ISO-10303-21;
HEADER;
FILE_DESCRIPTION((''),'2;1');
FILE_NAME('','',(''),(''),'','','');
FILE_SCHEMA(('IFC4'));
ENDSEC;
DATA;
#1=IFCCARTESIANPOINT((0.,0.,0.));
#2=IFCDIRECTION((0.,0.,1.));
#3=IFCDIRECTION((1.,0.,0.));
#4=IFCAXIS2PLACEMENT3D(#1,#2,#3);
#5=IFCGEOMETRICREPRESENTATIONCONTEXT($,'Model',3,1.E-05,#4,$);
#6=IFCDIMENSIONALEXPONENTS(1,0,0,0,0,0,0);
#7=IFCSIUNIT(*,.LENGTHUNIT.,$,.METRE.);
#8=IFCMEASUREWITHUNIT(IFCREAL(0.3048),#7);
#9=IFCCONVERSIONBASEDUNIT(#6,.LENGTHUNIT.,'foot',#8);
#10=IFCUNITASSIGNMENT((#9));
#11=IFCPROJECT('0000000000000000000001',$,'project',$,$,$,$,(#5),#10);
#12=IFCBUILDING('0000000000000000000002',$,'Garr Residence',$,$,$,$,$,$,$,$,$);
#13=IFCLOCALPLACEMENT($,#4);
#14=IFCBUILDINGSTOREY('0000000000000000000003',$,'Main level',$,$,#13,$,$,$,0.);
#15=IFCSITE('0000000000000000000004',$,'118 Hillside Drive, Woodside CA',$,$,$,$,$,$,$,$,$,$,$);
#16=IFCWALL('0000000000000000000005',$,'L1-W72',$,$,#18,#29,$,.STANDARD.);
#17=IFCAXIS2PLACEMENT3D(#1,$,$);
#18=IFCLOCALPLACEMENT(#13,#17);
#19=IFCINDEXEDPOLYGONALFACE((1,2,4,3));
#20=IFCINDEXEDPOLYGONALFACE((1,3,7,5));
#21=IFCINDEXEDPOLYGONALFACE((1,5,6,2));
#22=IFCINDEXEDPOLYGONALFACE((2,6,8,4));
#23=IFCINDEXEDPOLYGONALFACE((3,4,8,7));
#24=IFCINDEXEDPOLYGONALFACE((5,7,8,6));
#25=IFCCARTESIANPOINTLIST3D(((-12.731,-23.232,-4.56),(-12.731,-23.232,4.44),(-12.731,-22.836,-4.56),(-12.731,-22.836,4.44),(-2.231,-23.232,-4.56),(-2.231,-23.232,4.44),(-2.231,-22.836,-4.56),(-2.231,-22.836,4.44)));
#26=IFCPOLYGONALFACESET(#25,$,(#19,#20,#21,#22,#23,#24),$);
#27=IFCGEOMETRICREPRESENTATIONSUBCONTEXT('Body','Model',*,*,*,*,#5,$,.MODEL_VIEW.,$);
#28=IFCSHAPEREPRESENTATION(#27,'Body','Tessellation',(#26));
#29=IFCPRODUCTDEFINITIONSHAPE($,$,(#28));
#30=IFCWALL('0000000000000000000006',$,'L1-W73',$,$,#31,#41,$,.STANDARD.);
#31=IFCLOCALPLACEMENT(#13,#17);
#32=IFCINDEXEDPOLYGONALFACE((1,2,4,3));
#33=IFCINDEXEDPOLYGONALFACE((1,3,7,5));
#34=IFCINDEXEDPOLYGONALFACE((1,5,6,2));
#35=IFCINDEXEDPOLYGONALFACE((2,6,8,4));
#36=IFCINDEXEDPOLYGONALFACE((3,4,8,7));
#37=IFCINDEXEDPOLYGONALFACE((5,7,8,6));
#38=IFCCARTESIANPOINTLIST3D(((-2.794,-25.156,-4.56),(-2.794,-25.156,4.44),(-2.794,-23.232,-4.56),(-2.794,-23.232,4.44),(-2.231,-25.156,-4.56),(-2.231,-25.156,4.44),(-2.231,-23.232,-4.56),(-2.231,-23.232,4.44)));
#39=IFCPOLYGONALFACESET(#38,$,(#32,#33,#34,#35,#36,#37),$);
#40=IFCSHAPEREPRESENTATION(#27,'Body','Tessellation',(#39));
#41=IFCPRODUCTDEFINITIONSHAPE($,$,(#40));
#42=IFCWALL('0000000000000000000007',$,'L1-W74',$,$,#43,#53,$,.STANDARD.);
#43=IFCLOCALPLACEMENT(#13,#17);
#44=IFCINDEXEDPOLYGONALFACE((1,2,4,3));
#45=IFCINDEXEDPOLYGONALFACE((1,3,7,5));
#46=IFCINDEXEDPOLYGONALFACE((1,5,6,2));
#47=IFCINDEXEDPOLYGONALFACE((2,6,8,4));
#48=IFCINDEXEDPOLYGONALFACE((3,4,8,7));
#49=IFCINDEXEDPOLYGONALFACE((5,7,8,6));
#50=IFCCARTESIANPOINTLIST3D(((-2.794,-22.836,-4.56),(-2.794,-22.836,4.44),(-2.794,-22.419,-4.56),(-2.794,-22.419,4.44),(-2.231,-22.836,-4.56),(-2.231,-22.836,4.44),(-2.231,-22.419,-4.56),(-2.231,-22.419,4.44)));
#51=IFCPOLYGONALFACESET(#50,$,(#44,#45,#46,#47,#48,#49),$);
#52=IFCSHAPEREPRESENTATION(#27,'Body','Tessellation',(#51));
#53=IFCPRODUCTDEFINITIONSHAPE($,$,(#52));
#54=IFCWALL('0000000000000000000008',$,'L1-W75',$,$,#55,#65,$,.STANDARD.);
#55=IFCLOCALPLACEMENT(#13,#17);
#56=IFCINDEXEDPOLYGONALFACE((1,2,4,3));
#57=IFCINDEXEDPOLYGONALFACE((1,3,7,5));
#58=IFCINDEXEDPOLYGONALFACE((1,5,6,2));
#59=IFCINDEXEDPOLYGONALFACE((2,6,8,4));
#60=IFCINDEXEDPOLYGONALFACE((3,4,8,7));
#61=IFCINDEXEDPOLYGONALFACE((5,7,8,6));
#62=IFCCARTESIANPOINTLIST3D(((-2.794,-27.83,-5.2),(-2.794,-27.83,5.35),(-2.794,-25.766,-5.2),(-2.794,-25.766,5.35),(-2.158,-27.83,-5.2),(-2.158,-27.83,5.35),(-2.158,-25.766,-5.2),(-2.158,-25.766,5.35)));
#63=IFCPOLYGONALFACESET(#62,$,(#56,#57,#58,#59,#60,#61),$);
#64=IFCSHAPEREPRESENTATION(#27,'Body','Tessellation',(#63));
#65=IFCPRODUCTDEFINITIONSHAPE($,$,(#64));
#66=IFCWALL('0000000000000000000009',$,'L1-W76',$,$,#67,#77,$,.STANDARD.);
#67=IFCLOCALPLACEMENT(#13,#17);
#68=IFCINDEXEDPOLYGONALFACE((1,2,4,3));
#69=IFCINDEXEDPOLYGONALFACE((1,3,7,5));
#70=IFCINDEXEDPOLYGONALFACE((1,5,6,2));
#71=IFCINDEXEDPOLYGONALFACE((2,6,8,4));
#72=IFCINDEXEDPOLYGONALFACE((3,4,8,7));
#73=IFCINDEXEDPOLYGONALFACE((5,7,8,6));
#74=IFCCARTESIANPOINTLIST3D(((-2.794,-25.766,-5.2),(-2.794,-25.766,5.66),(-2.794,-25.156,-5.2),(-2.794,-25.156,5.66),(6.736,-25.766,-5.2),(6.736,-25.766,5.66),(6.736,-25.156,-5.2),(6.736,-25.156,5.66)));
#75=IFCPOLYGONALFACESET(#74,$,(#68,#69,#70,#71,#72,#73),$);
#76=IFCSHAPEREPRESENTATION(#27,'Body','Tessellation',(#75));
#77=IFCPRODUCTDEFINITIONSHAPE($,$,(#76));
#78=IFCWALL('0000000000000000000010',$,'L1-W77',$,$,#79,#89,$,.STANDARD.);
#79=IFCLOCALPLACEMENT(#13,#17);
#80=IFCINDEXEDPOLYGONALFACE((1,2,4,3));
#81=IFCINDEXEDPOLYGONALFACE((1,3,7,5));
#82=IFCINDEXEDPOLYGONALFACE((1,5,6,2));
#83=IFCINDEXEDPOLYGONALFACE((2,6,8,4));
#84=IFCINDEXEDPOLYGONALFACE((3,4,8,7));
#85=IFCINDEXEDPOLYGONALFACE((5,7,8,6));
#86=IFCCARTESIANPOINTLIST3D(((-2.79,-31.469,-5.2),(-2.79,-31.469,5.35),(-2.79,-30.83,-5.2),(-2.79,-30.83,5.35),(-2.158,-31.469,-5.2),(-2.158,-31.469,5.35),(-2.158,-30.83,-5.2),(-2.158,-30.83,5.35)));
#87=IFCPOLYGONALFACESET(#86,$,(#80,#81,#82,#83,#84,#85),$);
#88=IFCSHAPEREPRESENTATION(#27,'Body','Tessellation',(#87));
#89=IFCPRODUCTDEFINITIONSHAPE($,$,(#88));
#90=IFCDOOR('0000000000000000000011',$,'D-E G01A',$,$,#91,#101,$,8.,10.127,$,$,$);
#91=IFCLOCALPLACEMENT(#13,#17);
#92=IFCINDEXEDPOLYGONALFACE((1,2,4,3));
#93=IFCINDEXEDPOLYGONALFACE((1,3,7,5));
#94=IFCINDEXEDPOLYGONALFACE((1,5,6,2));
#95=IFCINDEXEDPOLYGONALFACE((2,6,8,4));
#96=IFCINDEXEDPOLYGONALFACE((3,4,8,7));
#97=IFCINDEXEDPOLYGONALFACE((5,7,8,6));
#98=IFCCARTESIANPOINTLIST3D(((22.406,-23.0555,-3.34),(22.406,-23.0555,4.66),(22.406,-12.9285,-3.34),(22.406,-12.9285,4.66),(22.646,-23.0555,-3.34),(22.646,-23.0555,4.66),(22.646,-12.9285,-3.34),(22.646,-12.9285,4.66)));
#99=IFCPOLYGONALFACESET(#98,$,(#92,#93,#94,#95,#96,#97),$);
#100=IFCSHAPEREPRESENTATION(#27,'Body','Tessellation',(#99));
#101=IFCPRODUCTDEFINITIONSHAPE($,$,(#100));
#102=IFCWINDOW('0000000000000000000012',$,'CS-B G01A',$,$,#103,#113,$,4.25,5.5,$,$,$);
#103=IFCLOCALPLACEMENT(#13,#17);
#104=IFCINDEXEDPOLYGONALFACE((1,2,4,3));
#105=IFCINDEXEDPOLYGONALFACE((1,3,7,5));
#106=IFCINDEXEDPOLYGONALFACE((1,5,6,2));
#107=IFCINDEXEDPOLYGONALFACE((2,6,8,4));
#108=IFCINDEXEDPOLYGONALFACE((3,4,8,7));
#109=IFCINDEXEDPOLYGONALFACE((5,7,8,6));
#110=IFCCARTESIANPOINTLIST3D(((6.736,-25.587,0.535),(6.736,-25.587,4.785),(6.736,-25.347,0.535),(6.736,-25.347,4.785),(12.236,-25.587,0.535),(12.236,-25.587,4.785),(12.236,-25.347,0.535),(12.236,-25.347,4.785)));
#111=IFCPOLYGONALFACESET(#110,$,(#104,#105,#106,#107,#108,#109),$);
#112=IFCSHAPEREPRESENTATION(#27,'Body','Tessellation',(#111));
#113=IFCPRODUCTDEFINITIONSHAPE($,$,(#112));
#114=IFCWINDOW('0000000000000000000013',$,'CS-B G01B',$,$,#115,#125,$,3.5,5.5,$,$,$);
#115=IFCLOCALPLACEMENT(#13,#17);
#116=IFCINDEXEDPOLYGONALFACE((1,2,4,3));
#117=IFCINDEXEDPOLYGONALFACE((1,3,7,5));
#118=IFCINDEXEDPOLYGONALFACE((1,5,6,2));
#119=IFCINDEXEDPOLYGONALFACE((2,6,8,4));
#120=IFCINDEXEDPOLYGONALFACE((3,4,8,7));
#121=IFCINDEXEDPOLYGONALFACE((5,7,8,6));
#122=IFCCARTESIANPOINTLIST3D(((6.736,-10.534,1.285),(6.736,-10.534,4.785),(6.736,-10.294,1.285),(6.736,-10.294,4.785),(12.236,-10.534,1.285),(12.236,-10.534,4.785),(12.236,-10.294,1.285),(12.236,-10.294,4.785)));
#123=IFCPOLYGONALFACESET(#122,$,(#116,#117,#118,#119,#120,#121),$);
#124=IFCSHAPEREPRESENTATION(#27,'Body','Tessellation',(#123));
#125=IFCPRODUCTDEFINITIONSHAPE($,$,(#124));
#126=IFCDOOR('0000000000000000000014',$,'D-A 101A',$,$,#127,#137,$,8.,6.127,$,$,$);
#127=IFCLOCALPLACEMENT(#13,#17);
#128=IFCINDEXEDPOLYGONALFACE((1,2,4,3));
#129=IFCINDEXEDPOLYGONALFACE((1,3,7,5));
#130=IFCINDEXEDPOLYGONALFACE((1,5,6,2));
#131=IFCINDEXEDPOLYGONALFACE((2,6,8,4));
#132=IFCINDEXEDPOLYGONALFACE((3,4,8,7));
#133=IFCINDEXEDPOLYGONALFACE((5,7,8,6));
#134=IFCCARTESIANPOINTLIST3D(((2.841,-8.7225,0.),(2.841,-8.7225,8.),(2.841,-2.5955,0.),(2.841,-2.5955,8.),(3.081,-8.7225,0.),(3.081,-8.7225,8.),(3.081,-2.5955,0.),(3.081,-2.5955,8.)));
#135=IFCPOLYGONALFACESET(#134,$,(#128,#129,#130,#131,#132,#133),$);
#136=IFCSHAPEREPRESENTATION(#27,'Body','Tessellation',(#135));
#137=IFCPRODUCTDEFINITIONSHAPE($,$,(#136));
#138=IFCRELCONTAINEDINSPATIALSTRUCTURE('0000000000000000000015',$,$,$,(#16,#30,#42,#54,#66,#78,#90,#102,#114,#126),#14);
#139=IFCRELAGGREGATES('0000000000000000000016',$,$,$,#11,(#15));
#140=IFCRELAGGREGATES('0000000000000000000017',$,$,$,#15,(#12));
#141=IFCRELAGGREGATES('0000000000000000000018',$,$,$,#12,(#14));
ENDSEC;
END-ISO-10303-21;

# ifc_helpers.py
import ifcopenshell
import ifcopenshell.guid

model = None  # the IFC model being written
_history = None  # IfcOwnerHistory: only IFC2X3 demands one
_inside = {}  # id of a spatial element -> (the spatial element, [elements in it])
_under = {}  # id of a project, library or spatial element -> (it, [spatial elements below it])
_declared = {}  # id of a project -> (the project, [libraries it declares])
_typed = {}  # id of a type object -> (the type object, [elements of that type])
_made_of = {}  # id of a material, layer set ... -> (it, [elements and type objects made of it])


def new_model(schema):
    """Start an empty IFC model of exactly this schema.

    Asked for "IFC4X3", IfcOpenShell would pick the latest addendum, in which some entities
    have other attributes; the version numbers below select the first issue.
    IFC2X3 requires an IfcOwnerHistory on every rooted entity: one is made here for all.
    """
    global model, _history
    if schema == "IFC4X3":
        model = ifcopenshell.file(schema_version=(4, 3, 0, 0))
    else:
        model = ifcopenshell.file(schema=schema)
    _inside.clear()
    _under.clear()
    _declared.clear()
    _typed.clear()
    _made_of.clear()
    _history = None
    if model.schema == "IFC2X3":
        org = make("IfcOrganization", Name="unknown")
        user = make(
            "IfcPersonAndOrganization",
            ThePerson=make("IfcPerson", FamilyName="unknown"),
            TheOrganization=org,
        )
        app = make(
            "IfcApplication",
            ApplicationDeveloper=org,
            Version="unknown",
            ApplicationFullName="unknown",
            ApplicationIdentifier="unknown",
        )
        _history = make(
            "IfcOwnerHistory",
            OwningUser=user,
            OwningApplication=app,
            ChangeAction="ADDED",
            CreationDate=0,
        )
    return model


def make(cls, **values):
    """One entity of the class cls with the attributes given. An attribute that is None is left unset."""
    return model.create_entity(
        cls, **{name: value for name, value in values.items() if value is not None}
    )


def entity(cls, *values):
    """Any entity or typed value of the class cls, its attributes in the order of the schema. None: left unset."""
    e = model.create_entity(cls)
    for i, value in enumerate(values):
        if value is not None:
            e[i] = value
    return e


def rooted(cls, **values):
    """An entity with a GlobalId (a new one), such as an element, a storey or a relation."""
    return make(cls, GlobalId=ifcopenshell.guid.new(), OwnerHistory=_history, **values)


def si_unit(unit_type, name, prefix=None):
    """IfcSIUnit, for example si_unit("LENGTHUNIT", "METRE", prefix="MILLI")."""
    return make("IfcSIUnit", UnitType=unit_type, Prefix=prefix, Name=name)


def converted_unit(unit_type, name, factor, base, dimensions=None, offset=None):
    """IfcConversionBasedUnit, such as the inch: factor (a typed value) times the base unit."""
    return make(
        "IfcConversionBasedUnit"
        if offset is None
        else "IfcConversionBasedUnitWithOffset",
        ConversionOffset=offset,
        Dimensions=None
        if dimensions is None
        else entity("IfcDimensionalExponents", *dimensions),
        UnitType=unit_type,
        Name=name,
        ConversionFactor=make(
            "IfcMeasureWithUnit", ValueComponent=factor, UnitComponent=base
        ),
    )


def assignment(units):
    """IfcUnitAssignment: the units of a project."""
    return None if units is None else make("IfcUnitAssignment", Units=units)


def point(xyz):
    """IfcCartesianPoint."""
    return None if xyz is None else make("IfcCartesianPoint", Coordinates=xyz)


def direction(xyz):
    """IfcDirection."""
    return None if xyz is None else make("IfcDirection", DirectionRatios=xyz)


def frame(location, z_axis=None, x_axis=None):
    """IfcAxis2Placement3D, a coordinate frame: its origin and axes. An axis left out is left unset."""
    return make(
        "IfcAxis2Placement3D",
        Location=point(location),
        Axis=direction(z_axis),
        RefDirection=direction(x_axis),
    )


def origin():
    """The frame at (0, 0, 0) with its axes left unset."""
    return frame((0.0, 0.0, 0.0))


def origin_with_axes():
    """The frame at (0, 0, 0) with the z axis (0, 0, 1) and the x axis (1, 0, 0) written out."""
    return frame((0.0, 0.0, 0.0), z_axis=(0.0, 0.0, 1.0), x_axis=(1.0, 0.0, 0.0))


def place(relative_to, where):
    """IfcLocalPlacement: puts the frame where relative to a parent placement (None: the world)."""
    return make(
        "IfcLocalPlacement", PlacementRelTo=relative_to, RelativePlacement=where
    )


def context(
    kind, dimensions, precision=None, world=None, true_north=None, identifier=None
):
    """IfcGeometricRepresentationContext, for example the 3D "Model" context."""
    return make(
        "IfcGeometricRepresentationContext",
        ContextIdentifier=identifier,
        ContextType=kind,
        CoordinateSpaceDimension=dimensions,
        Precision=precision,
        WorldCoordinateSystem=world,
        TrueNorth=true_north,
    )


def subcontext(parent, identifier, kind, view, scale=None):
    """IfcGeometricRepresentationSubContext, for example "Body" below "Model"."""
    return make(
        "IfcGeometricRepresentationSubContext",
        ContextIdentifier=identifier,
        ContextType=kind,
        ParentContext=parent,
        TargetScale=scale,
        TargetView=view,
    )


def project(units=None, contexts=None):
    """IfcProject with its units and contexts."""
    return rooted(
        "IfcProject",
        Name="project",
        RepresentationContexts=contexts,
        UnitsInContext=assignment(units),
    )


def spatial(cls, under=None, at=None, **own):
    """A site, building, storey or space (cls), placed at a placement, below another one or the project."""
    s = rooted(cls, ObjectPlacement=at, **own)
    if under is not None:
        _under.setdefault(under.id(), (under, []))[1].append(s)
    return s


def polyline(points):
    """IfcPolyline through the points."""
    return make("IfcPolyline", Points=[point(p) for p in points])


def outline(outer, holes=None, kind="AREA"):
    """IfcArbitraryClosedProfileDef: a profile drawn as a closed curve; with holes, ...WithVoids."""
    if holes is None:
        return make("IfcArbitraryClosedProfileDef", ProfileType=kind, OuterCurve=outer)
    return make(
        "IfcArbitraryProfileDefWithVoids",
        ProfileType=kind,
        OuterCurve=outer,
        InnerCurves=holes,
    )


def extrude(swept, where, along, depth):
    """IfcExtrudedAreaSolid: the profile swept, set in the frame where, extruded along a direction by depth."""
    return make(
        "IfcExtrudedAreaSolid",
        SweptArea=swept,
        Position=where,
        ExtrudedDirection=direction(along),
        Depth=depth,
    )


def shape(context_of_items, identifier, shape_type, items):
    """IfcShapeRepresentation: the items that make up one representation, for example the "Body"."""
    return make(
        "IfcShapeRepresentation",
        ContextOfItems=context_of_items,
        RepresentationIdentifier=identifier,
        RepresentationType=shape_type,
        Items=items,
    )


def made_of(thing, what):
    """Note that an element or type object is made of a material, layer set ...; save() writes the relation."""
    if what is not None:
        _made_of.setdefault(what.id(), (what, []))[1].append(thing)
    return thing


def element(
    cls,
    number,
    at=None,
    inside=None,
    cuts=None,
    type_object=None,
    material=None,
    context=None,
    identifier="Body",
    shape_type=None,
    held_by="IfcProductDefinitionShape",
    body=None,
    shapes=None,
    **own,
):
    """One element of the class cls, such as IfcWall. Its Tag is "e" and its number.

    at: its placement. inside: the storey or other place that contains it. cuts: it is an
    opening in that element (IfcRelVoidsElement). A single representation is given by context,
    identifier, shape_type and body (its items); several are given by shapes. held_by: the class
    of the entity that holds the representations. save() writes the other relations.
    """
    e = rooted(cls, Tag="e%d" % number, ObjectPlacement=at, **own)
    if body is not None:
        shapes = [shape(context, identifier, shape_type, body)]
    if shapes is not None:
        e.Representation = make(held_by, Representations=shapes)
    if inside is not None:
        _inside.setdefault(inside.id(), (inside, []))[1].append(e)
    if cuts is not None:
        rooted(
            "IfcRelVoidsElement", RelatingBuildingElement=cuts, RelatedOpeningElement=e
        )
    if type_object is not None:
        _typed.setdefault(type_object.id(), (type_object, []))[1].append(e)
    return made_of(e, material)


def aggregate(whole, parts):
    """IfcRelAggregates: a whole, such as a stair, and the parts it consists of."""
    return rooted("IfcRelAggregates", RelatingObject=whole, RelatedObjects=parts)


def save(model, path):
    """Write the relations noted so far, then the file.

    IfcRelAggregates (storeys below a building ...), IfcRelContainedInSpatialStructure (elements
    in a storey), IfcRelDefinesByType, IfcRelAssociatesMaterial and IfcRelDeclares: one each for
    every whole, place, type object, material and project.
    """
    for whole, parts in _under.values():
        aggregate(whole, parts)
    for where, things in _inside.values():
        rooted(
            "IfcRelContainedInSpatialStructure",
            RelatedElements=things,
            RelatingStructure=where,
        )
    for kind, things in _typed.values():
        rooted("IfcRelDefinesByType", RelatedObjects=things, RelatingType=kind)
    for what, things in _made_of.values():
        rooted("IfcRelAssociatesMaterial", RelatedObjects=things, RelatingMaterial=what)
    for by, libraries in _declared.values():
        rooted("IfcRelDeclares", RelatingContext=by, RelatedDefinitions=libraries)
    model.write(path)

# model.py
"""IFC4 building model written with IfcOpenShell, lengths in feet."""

from ifc_helpers import new_model, entity, si_unit, converted_unit, frame, origin, origin_with_axes, place, context, subcontext, project, spatial, polyline, outline, extrude, element, save


model = new_model("IFC4")

# Units and contexts
model_context = context("Model", 3, precision=1e-05, world=origin_with_axes())
body_context = subcontext(model_context, "Body", "Model", "MODEL_VIEW")
ifc_project = project(units=[converted_unit("LENGTHUNIT", "foot", entity("IfcReal", 0.3048), si_unit("LENGTHUNIT", "METRE"), dimensions=[1, 0, 0, 0, 0, 0, 0])], contexts=[model_context])

# Site, building, storey
site = spatial("IfcSite", under=ifc_project, Name="118 Hillside Drive, Woodside CA")
building = spatial("IfcBuilding", under=site, Name="Garr Residence")
storey_placement = place(None, origin_with_axes())
storey = spatial("IfcBuildingStorey", under=building, at=storey_placement, Name="Main level", Elevation=0.0)

# Walls
wall_1_placement = place(storey_placement, frame((0.0, 0.0, -4.56), z_axis=(0.0, 0.0, 1.0), x_axis=(1.0, 0.0, 0.0)))
element("IfcWall", 1, at=wall_1_placement, inside=storey, Name="L1-W72", PredefinedType="STANDARD", context=body_context, shape_type="SweptSolid", body=[
    extrude(outline(polyline([(-2.231, -23.232), (-2.231, -22.836), (-12.731, -22.836), (-12.731, -23.232), (-2.231, -23.232)])), origin(), (0.0, 0.0, 1.0), 9.0),
])
wall_2_placement = place(storey_placement, frame((0.0, 0.0, -4.56), z_axis=(0.0, 0.0, 1.0), x_axis=(1.0, 0.0, 0.0)))
element("IfcWall", 2, at=wall_2_placement, inside=storey, Name="L1-W73", PredefinedType="STANDARD", context=body_context, shape_type="SweptSolid", body=[
    extrude(outline(polyline([(-2.231, -25.156), (-2.231, -23.232), (-2.794, -23.232), (-2.794, -25.156), (-2.231, -25.156)])), origin(), (0.0, 0.0, 1.0), 9.0),
])
wall_3_placement = place(storey_placement, frame((0.0, 0.0, -4.56), z_axis=(0.0, 0.0, 1.0), x_axis=(1.0, 0.0, 0.0)))
element("IfcWall", 3, at=wall_3_placement, inside=storey, Name="L1-W74", PredefinedType="STANDARD", context=body_context, shape_type="SweptSolid", body=[
    extrude(outline(polyline([(-2.231, -22.836), (-2.231, -22.419), (-2.794, -22.419), (-2.794, -22.836), (-2.231, -22.836)])), origin(), (0.0, 0.0, 1.0), 9.0),
])
wall_4_placement = place(storey_placement, frame((0.0, 0.0, -5.2), z_axis=(0.0, 0.0, 1.0), x_axis=(1.0, 0.0, 0.0)))
element("IfcWall", 4, at=wall_4_placement, inside=storey, Name="L1-W75", PredefinedType="STANDARD", context=body_context, shape_type="SweptSolid", body=[
    extrude(outline(polyline([(-2.158, -27.83), (-2.158, -25.766), (-2.794, -25.766), (-2.794, -27.83), (-2.158, -27.83)])), origin(), (0.0, 0.0, 1.0), 10.55),
])
wall_5_placement = place(storey_placement, frame((0.0, 0.0, -5.2), z_axis=(0.0, 0.0, 1.0), x_axis=(1.0, 0.0, 0.0)))
element("IfcWall", 5, at=wall_5_placement, inside=storey, Name="L1-W76", PredefinedType="STANDARD", context=body_context, shape_type="SweptSolid", body=[
    extrude(outline(polyline([(6.736, -25.766), (6.736, -25.156), (-2.794, -25.156), (-2.794, -25.766), (6.736, -25.766)])), origin(), (0.0, 0.0, 1.0), 10.86),
])
wall_6_placement = place(storey_placement, frame((0.0, 0.0, -5.2), z_axis=(0.0, 0.0, 1.0), x_axis=(1.0, 0.0, 0.0)))
element("IfcWall", 6, at=wall_6_placement, inside=storey, Name="L1-W77", PredefinedType="STANDARD", context=body_context, shape_type="SweptSolid", body=[
    extrude(outline(polyline([(-2.158, -31.469), (-2.158, -30.83), (-2.79, -30.83), (-2.79, -31.469), (-2.158, -31.469)])), origin(), (0.0, 0.0, 1.0), 10.55),
])

# Door
door_1_placement = place(storey_placement, frame((22.526, -17.992, -3.34), z_axis=(0.0, 0.0, 1.0), x_axis=(0.0, 1.0, 0.0)))
element("IfcDoor", 7, at=door_1_placement, inside=storey, Name="D-E G01A", OverallHeight=8.0, OverallWidth=10.127, context=body_context, shape_type="SweptSolid", body=[
    extrude(outline(polyline([(-5.0635, -0.12), (5.0635, -0.12), (5.0635, 0.12), (-5.0635, 0.12), (-5.0635, -0.12)])), origin(), (0.0, 0.0, 1.0), 8.0),
])

# Windows
window_1_placement = place(storey_placement, frame((9.486, -25.467, 0.535), z_axis=(0.0, 0.0, 1.0), x_axis=(1.0, 0.0, 0.0)))
element("IfcWindow", 8, at=window_1_placement, inside=storey, Name="CS-B G01A", OverallHeight=4.25, OverallWidth=5.5, context=body_context, shape_type="SweptSolid", body=[
    extrude(outline(polyline([(-2.75, -0.12), (2.75, -0.12), (2.75, 0.12), (-2.75, 0.12), (-2.75, -0.12)])), origin(), (0.0, 0.0, 1.0), 4.25),
])
window_2_placement = place(storey_placement, frame((9.486, -10.414, 1.285), z_axis=(0.0, 0.0, 1.0), x_axis=(1.0, 0.0, 0.0)))
element("IfcWindow", 9, at=window_2_placement, inside=storey, Name="CS-B G01B", OverallHeight=3.5, OverallWidth=5.5, context=body_context, shape_type="SweptSolid", body=[
    extrude(outline(polyline([(-2.75, -0.12), (2.75, -0.12), (2.75, 0.12), (-2.75, 0.12), (-2.75, -0.12)])), origin(), (0.0, 0.0, 1.0), 3.5),
])

# Door
door_2_placement = place(storey_placement, frame((2.961, -5.659, 0.0), z_axis=(0.0, 0.0, 1.0), x_axis=(0.0, 1.0, 0.0)))
element("IfcDoor", 10, at=door_2_placement, inside=storey, Name="D-A 101A", OverallHeight=8.0, OverallWidth=6.127, context=body_context, shape_type="SweptSolid", body=[
    extrude(outline(polyline([(-3.0635, -0.12), (3.0635, -0.12), (3.0635, 0.12), (-3.0635, 0.12), (-3.0635, -0.12)])), origin(), (0.0, 0.0, 1.0), 8.0),
])

save(model, "model.ifc")
